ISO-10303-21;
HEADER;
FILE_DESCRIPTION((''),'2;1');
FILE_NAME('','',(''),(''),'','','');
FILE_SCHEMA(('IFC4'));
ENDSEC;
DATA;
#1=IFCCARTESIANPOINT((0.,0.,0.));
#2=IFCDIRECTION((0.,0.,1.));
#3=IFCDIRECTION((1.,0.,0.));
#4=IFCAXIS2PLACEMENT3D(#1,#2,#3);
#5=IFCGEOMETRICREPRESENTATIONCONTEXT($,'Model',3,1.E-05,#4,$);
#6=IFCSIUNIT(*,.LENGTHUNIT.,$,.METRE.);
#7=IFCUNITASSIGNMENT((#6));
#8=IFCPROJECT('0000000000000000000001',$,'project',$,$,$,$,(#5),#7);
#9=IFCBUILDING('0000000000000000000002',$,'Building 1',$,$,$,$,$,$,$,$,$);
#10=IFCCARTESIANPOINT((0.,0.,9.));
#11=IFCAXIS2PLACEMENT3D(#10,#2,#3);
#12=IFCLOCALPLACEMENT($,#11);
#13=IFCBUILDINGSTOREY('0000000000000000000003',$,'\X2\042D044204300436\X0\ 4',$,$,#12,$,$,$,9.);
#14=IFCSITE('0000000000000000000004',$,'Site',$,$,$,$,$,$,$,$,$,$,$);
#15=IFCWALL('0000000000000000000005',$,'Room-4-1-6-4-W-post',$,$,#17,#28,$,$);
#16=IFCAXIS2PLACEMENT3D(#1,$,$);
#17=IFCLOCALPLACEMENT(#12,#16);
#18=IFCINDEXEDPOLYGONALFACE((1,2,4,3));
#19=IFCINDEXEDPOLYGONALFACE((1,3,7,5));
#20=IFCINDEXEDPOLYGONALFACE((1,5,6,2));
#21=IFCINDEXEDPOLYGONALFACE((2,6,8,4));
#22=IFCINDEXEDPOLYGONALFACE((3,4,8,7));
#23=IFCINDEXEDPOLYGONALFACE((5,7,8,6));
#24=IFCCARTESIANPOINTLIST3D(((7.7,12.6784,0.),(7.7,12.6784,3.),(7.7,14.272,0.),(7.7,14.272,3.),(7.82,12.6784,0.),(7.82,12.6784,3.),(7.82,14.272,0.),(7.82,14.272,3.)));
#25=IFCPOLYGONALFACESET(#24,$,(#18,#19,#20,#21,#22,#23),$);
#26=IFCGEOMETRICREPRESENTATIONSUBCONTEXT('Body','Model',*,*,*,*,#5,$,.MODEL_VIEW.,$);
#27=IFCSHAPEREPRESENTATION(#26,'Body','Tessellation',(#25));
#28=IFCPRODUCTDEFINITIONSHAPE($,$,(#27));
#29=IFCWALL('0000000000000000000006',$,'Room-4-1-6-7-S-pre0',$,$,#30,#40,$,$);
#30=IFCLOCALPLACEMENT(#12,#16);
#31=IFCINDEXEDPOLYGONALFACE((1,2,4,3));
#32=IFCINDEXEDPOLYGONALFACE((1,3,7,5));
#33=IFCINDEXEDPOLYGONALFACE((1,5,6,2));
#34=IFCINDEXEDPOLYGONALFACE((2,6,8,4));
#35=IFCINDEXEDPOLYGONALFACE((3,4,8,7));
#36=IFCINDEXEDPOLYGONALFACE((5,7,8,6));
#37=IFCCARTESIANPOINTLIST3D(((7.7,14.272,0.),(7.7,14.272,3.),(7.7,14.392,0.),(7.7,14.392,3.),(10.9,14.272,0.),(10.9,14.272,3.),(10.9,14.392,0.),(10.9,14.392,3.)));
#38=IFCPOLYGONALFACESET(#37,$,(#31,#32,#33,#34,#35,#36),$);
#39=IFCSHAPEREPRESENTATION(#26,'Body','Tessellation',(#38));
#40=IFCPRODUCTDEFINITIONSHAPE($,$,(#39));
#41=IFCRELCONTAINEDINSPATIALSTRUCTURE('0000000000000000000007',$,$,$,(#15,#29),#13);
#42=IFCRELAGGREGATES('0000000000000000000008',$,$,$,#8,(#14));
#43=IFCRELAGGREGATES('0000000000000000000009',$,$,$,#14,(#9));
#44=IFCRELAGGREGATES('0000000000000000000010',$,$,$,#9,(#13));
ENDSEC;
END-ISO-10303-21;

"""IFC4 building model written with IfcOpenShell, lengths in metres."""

from ifc_helpers import new_model, si_unit, frame, origin_with_axes, place, context, subcontext, project, spatial, indexed_curve, outline, extrude, element, save


model = new_model("IFC4")

# Units and contexts
model_context = context("Model", 3, precision=1e-05, world=origin_with_axes())
body_context = subcontext(model_context, "Body", "Model", "MODEL_VIEW")
ifc_project = project(units=[si_unit("LENGTHUNIT", "METRE")], contexts=[model_context])

# Site, building, storey
site = spatial("IfcSite", under=ifc_project, Name="Site")
building = spatial("IfcBuilding", under=site, Name="Building 1")
storey_placement = place(None, frame((0.0, 0.0, 9.0), z_axis=(0.0, 0.0, 1.0), x_axis=(1.0, 0.0, 0.0)))
storey = spatial("IfcBuildingStorey", under=building, at=storey_placement, Name="Этаж 4", Elevation=9.0)

# Walls
wall_1_placement = place(storey_placement, frame((7.7, 14.272, 0.0), z_axis=(0.0, 0.0, 1.0), x_axis=(0.0, -1.0, 0.0)))
element("IfcWall", 1, at=wall_1_placement, inside=storey, Name="Room-4-1-6-4-W-post", context=body_context, shape_type="SweptSolid", body=[
    extrude(outline(indexed_curve([(0.0, 0.0), (0.0, 0.12), (1.5936, 0.12), (1.5936, 0.0), (0.0, 0.0)], self_intersect=False)), origin_with_axes(), (0.0, 0.0, 1.0), 3.0),
])
wall_2_placement = place(storey_placement, frame((7.7, 14.272, 0.0), z_axis=(0.0, 0.0, 1.0), x_axis=(1.0, 0.0, 0.0)))
element("IfcWall", 2, at=wall_2_placement, inside=storey, Name="Room-4-1-6-7-S-pre0", context=body_context, shape_type="SweptSolid", body=[
    extrude(outline(indexed_curve([(0.0, 0.0), (0.0, 0.12), (3.2, 0.12), (3.2, 0.0), (0.0, 0.0)], self_intersect=False)), origin_with_axes(), (0.0, 0.0, 1.0), 3.0),
])

save(model, "model.ifc")
